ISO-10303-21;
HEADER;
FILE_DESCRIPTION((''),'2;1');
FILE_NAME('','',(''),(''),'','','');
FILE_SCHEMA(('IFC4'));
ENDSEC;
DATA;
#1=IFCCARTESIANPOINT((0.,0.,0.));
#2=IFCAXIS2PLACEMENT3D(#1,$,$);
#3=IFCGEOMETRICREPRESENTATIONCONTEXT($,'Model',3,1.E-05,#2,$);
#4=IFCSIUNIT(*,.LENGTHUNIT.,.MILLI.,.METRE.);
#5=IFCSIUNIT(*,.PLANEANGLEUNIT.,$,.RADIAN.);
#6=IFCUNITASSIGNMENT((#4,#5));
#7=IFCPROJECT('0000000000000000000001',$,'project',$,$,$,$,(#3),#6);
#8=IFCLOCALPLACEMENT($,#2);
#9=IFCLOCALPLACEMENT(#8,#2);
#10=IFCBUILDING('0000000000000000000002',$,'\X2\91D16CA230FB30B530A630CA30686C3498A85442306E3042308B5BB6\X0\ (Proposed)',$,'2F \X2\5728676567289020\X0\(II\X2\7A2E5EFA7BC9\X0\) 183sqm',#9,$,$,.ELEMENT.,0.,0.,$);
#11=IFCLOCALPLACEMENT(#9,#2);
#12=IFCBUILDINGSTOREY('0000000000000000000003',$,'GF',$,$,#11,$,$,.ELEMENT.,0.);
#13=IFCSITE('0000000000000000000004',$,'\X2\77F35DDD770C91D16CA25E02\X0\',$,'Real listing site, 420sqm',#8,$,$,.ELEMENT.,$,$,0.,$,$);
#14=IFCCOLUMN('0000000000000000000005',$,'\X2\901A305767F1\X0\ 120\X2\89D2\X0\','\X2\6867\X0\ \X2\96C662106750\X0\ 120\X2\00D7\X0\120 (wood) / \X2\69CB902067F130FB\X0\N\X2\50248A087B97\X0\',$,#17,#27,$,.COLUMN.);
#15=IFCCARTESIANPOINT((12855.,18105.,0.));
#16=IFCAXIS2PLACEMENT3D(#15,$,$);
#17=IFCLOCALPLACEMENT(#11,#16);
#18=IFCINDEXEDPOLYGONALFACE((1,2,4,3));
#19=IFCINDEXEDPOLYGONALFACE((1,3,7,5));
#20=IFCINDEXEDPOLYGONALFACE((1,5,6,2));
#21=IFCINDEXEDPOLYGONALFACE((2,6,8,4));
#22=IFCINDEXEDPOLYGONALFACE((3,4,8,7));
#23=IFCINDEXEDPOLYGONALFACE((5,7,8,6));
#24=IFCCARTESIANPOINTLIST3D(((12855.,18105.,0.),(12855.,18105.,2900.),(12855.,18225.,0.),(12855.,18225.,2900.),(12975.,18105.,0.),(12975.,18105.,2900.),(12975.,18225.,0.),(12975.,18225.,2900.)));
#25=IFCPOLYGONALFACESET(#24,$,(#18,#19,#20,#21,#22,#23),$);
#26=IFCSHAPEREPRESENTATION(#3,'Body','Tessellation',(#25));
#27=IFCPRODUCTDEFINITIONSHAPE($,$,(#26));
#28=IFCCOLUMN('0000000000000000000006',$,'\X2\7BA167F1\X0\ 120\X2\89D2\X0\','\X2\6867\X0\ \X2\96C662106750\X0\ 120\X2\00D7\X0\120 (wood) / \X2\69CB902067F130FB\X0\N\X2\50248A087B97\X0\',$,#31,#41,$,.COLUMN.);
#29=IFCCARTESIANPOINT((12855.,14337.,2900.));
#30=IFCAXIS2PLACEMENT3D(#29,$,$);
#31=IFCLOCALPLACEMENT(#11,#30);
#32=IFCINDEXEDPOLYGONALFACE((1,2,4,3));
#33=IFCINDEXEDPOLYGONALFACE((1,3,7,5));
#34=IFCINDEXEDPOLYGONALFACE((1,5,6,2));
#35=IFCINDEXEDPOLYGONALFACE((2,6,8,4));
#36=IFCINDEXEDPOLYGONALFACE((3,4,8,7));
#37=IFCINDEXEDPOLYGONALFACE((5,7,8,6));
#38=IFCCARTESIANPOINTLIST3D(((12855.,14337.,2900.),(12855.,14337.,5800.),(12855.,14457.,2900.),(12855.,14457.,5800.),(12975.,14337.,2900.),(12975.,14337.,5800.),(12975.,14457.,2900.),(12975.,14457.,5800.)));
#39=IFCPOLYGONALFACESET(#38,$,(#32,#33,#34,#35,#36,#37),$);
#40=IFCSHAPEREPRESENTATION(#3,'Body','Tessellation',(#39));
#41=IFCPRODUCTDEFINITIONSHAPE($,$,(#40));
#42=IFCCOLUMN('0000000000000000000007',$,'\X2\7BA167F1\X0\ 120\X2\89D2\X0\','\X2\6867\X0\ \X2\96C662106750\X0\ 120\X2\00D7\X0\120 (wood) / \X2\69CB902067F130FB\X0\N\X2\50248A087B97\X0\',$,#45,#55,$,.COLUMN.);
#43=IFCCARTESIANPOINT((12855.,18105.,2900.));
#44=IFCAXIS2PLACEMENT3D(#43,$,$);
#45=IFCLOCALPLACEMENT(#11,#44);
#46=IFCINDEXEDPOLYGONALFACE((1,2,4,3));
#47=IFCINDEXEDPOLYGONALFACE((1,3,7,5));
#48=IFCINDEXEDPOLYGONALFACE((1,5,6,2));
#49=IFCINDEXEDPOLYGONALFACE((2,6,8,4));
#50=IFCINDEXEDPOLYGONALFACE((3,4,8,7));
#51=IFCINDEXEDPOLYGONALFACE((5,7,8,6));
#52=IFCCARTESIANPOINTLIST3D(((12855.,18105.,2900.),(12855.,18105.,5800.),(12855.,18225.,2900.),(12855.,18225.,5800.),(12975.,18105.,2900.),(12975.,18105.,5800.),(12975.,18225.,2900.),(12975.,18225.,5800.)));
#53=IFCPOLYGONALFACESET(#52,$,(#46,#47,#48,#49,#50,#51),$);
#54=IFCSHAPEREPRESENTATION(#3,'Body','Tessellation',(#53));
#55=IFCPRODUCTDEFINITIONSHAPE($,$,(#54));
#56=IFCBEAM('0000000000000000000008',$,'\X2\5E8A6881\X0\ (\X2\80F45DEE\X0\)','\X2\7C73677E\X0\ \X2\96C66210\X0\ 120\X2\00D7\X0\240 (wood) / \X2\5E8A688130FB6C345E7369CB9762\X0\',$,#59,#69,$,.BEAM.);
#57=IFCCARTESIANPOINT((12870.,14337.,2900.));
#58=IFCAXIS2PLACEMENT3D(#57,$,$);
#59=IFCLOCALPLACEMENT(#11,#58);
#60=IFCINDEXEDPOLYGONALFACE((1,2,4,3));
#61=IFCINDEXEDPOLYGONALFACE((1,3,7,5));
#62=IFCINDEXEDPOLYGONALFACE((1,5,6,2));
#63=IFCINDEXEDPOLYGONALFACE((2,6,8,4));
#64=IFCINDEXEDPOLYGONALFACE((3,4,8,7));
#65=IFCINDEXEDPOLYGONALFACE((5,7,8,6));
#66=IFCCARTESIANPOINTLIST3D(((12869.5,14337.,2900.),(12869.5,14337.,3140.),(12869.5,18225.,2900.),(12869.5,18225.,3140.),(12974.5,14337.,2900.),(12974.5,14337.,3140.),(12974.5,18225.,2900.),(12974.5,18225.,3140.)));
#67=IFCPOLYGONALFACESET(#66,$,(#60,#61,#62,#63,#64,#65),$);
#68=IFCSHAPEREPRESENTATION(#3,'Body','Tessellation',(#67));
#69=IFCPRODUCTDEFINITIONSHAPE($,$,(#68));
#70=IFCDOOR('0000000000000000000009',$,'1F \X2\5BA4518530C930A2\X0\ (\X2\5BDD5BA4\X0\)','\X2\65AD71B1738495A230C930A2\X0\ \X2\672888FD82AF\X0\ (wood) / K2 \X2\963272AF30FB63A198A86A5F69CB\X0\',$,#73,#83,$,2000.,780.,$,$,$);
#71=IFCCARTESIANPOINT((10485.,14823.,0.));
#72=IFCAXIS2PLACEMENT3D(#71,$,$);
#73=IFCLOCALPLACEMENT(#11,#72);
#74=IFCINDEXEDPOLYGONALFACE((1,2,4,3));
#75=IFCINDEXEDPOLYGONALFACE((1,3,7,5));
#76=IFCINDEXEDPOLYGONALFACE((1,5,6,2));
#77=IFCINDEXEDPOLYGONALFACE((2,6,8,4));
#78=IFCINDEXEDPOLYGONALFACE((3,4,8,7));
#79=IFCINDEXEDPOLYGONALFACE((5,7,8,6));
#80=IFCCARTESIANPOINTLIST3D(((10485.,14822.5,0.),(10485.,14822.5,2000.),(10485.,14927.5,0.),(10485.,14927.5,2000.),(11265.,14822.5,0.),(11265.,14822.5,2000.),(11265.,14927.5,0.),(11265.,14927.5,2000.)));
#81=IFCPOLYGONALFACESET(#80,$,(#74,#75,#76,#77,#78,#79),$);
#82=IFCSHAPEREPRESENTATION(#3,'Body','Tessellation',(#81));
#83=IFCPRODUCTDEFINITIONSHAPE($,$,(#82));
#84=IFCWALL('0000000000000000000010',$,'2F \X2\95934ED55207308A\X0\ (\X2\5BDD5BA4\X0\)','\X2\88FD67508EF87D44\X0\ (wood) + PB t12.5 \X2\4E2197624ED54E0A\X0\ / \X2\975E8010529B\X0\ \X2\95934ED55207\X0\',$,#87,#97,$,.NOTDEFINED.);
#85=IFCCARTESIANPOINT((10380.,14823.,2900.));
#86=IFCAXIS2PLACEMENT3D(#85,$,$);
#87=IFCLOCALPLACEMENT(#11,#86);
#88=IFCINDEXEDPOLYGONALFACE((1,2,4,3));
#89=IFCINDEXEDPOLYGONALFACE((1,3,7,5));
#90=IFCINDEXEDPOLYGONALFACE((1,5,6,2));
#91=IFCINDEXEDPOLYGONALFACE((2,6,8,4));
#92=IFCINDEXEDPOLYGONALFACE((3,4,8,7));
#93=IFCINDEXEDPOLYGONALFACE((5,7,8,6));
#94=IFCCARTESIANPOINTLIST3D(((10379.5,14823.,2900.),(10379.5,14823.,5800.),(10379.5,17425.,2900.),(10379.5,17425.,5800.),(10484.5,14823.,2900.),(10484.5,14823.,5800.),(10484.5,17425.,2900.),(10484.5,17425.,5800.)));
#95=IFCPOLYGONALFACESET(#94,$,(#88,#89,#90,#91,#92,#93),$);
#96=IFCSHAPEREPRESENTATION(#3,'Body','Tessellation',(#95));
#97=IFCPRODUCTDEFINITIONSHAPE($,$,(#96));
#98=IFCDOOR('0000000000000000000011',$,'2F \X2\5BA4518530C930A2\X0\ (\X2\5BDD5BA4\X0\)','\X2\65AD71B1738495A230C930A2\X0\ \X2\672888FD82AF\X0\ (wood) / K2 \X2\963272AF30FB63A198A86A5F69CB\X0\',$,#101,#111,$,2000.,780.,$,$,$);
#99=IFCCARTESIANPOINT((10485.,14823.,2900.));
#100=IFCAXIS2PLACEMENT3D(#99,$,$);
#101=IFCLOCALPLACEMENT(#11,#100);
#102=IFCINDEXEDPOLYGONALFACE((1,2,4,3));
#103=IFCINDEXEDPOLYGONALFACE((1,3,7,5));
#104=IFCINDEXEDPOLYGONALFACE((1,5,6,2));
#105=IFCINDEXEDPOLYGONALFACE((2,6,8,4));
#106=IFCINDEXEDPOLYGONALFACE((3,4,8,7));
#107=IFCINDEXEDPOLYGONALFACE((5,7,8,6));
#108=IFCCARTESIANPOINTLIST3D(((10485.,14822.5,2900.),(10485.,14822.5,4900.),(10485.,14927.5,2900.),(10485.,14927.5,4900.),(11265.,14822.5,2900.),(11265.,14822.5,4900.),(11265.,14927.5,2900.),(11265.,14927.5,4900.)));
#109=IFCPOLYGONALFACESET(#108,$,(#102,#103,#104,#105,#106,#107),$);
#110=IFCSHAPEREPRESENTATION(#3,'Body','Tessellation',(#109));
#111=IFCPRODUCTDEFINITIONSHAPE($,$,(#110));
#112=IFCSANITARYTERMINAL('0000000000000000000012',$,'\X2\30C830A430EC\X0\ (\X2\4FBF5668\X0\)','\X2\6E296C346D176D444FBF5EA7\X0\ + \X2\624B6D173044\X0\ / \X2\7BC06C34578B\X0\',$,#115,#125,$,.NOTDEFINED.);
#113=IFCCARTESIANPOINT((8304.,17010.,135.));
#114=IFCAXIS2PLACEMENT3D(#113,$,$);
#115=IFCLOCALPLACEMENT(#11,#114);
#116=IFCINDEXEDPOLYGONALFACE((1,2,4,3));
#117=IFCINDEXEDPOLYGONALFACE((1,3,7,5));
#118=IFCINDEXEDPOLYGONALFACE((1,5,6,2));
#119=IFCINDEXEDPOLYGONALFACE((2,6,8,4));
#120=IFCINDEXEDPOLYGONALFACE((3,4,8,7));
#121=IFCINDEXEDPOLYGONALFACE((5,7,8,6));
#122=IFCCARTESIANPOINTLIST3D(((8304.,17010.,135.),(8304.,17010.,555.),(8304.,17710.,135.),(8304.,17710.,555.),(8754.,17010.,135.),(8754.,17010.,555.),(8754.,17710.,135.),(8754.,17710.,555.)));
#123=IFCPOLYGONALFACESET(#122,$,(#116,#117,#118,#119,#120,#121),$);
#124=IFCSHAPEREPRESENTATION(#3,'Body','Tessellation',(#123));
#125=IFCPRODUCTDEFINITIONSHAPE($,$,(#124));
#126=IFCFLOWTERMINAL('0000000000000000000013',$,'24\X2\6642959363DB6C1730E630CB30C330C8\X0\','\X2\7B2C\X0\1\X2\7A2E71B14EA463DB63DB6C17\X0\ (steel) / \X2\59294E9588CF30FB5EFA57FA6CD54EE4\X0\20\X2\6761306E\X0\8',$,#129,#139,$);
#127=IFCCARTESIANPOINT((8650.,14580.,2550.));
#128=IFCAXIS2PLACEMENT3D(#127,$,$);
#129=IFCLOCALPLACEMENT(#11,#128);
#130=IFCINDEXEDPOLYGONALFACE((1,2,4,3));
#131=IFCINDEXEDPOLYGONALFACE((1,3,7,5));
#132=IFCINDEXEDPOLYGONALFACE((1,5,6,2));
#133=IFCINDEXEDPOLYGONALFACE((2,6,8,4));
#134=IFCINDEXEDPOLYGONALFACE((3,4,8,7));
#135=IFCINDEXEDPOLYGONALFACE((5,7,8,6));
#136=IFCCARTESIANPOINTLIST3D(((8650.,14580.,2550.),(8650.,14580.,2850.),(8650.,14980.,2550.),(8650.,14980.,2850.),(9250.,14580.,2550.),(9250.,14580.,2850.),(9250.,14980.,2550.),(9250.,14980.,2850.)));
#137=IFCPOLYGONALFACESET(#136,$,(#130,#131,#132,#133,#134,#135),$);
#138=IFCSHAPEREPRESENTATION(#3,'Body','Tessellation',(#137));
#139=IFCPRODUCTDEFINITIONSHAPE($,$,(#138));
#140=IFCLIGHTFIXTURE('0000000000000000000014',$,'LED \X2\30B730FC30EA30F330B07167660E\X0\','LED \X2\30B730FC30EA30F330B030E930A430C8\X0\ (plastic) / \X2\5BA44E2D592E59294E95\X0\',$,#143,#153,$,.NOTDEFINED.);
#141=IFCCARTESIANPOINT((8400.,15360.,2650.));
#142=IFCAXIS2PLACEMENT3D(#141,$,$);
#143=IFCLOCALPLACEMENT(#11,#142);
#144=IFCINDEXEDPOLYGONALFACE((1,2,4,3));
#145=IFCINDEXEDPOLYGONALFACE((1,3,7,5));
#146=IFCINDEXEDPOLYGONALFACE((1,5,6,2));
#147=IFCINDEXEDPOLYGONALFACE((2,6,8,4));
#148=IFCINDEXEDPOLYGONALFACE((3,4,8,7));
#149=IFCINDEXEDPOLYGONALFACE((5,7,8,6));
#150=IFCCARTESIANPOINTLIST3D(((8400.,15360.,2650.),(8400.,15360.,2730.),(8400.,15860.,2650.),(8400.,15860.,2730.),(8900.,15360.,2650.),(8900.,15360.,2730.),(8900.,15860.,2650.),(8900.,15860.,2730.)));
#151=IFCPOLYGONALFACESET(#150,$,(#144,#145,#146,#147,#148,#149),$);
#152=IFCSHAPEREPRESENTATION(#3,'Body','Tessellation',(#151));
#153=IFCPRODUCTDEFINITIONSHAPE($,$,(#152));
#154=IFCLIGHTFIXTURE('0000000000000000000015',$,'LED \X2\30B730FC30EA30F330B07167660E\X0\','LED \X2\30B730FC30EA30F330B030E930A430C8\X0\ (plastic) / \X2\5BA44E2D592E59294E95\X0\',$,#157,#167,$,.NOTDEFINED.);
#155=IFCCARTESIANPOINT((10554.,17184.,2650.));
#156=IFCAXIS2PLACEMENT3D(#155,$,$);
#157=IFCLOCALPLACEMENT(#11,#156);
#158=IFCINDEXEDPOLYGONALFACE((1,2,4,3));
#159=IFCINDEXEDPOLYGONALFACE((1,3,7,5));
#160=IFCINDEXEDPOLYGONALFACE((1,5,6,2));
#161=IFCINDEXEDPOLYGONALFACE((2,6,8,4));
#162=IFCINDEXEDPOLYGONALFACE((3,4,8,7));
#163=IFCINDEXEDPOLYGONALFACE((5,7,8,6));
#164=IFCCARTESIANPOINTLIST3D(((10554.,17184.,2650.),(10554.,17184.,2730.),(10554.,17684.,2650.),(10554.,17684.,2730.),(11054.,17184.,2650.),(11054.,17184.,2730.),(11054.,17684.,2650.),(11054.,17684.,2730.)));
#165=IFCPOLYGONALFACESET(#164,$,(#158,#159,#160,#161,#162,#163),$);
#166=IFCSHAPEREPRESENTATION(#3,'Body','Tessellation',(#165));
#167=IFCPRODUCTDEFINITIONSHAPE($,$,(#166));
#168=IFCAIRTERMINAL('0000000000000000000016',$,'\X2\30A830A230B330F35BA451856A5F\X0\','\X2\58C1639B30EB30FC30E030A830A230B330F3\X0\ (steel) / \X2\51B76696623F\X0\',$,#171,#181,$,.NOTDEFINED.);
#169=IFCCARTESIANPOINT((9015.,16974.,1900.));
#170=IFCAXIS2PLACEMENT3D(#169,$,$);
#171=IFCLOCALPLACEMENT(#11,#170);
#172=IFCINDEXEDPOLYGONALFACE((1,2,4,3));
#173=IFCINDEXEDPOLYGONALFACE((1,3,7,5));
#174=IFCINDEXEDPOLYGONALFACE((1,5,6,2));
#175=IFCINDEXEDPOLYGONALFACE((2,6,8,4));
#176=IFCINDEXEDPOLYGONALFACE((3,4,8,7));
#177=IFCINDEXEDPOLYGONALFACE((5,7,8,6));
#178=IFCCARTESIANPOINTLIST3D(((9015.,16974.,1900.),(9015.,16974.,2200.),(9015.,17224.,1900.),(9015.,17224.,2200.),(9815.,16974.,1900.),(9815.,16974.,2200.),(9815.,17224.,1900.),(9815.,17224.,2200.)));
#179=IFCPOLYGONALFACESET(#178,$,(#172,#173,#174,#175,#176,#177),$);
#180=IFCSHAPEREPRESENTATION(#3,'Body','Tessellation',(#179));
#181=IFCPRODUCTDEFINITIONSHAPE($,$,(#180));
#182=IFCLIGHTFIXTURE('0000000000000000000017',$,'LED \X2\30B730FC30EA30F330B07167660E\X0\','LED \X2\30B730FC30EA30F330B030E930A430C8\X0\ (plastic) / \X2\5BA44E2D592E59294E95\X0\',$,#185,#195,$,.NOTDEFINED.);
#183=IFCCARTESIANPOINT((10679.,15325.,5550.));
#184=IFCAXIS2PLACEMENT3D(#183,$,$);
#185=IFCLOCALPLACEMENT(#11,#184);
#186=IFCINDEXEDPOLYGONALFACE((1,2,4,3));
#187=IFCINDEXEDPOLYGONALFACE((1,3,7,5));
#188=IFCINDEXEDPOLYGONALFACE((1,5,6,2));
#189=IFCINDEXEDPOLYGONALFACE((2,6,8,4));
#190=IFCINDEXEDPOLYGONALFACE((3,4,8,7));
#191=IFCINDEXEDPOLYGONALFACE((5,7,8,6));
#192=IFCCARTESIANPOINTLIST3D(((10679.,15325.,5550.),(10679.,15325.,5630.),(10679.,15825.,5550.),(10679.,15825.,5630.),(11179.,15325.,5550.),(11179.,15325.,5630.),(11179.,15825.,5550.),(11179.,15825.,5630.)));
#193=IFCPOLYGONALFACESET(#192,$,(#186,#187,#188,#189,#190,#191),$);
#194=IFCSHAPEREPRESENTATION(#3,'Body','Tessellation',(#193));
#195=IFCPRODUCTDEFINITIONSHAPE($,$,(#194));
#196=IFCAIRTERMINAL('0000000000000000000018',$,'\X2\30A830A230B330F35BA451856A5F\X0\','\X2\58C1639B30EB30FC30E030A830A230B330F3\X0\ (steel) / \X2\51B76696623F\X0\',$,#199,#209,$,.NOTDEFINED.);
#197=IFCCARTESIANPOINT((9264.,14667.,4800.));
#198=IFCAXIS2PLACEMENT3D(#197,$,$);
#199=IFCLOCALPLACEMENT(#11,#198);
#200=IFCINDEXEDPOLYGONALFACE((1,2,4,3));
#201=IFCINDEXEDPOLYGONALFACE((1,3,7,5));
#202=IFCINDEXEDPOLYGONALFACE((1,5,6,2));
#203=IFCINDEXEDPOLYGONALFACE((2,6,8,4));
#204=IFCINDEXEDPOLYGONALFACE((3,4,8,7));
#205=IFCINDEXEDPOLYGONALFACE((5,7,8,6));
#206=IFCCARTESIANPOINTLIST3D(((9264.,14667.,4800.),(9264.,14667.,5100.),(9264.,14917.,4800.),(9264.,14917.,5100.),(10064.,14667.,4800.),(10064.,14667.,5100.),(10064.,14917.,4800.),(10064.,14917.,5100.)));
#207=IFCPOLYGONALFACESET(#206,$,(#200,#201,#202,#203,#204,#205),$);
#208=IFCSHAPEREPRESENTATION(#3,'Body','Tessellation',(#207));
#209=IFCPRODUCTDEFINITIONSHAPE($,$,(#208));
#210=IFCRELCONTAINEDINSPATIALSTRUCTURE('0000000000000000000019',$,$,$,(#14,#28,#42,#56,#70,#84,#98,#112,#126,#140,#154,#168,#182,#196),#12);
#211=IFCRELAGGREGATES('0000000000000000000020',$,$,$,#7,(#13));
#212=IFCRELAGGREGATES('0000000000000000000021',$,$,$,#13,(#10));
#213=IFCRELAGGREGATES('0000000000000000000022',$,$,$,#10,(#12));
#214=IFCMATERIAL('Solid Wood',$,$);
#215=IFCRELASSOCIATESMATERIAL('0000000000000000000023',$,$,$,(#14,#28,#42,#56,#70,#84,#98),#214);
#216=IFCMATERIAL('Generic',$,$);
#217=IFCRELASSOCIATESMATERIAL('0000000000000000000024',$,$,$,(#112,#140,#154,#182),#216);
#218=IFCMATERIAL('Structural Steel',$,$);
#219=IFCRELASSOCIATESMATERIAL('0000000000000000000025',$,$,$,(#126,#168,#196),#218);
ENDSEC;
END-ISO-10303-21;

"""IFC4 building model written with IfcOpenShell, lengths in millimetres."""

from ifc_helpers import new_model, si_unit, frame, frame_2d, origin, place, context, project, spatial, rectangle, extrude, material, element, save


model = new_model("IFC4")

# Units and contexts
model_context = context("Model", 3, precision=1e-05, world=origin())
ifc_project = project(units=[si_unit("LENGTHUNIT", "METRE", prefix="MILLI"), si_unit("PLANEANGLEUNIT", "RADIAN")], contexts=[model_context])

# Site, building, storey
site_placement = place(None, origin())
site = spatial("IfcSite", under=ifc_project, at=site_placement, Name="石川県金沢市", ObjectType="Real listing site, 420sqm", CompositionType="ELEMENT", RefElevation=0.0)
building_placement = place(site_placement, origin())
building = spatial("IfcBuilding", under=site, at=building_placement, Name="金沢・サウナと水風呂のある家 (Proposed)", ObjectType="2F 在来木造(II種建築) 183sqm", CompositionType="ELEMENT", ElevationOfRefHeight=0.0, ElevationOfTerrain=0.0)
storey_placement = place(building_placement, origin())
storey = spatial("IfcBuildingStorey", under=building, at=storey_placement, Name="GF", CompositionType="ELEMENT", Elevation=0.0)

# Columns
ifc_material_1 = material(Name="Solid Wood")
column_1_placement = place(storey_placement, frame((12855.0, 18105.0, 0.0)))
element("IfcColumn", 1, at=column_1_placement, inside=storey, material=ifc_material_1, Name="通し柱 120角", Description="桧 集成材 120×120 (wood) / 構造柱・N値計算", PredefinedType="COLUMN", context=model_context, shape_type="SweptSolid", body=[
    extrude(rectangle(XDim=120.0, YDim=120.0, at=frame_2d((60.0, 60.0))), frame((12855.0, 18105.0, 0.0)), (0.0, 0.0, 1.0), 2900.0),
])
column_2_placement = place(storey_placement, frame((12855.0, 14337.0, 2900.0)))
element("IfcColumn", 2, at=column_2_placement, inside=storey, material=ifc_material_1, Name="管柱 120角", Description="桧 集成材 120×120 (wood) / 構造柱・N値計算", PredefinedType="COLUMN", context=model_context, shape_type="SweptSolid", body=[
    extrude(rectangle(XDim=120.0, YDim=120.0, at=frame_2d((60.0, 60.0))), frame((12855.0, 14337.0, 2900.0)), (0.0, 0.0, 1.0), 2900.0),
])
column_3_placement = place(storey_placement, frame((12855.0, 18105.0, 2900.0)))
element("IfcColumn", 3, at=column_3_placement, inside=storey, material=ifc_material_1, Name="管柱 120角", Description="桧 集成材 120×120 (wood) / 構造柱・N値計算", PredefinedType="COLUMN", context=model_context, shape_type="SweptSolid", body=[
    extrude(rectangle(XDim=120.0, YDim=120.0, at=frame_2d((60.0, 60.0))), frame((12855.0, 18105.0, 2900.0)), (0.0, 0.0, 1.0), 2900.0),
])

# Beam
beam_1_placement = place(storey_placement, frame((12870.0, 14337.0, 2900.0)))
element("IfcBeam", 4, at=beam_1_placement, inside=storey, material=ifc_material_1, Name="床梁 (胴差)", Description="米松 集成 120×240 (wood) / 床梁・水平構面", PredefinedType="BEAM", context=model_context, shape_type="SweptSolid", body=[
    extrude(rectangle(XDim=105.0, YDim=3888.0, at=frame_2d((52.0, 1944.0))), frame((12870.0, 14337.0, 2900.0)), (0.0, 0.0, 1.0), 240.0),
])

# Door
door_1_placement = place(storey_placement, frame((10485.0, 14823.0, 0.0)))
element("IfcDoor", 5, at=door_1_placement, inside=storey, material=ifc_material_1, Name="1F 室内ドア (寝室)", Description="断熱玄関ドア 木製芯 (wood) / K2 防犯・採風機構", OverallHeight=2000.0, OverallWidth=780.0, context=model_context, shape_type="SweptSolid", body=[
    extrude(rectangle(XDim=780.0, YDim=105.0, at=frame_2d((390.0, 52.0))), frame((10485.0, 14823.0, 0.0)), (0.0, 0.0, 1.0), 2000.0),
])

# Wall
wall_1_placement = place(storey_placement, frame((10380.0, 14823.0, 2900.0)))
element("IfcWall", 6, at=wall_1_placement, inside=storey, material=ifc_material_1, Name="2F 間仕切り (寝室)", Description="製材軸組 (wood) + PB t12.5 両面仕上 / 非耐力 間仕切", PredefinedType="NOTDEFINED", context=model_context, shape_type="SweptSolid", body=[
    extrude(rectangle(XDim=105.0, YDim=2602.0, at=frame_2d((52.0, 1301.0))), frame((10380.0, 14823.0, 2900.0)), (0.0, 0.0, 1.0), 2900.0),
])

# Door
door_2_placement = place(storey_placement, frame((10485.0, 14823.0, 2900.0)))
element("IfcDoor", 7, at=door_2_placement, inside=storey, material=ifc_material_1, Name="2F 室内ドア (寝室)", Description="断熱玄関ドア 木製芯 (wood) / K2 防犯・採風機構", OverallHeight=2000.0, OverallWidth=780.0, context=model_context, shape_type="SweptSolid", body=[
    extrude(rectangle(XDim=780.0, YDim=105.0, at=frame_2d((390.0, 52.0))), frame((10485.0, 14823.0, 2900.0)), (0.0, 0.0, 1.0), 2000.0),
])

# Sanitary terminal
ifc_material_2 = material(Name="Generic")
sanitary_terminal_placement = place(storey_placement, frame((8304.0, 17010.0, 135.0)))
element("IfcSanitaryTerminal", 8, at=sanitary_terminal_placement, inside=storey, material=ifc_material_2, Name="トイレ (便器)", Description="温水洗浄便座 + 手洗い / 節水型", PredefinedType="NOTDEFINED", context=model_context, shape_type="SweptSolid", body=[
    extrude(rectangle(XDim=450.0, YDim=700.0, at=frame_2d((225.0, 350.0))), frame((8304.0, 17010.0, 135.0)), (0.0, 0.0, 1.0), 420.0),
])

# Flow terminal
ifc_material_3 = material(Name="Structural Steel")
flow_terminal_placement = place(storey_placement, frame((8650.0, 14580.0, 2550.0)))
element("IfcFlowTerminal", 9, at=flow_terminal_placement, inside=storey, material=ifc_material_3, Name="24時間換気ユニット", Description="第1種熱交換換気 (steel) / 天井裏・建基法令20条の8", context=model_context, shape_type="SweptSolid", body=[
    extrude(rectangle(XDim=600.0, YDim=400.0, at=frame_2d((300.0, 200.0))), frame((8650.0, 14580.0, 2550.0)), (0.0, 0.0, 1.0), 300.0),
])

# Light fixtures
light_fixture_1_placement = place(storey_placement, frame((8400.0, 15360.0, 2650.0)))
element("IfcLightFixture", 10, at=light_fixture_1_placement, inside=storey, material=ifc_material_2, Name="LED シーリング照明", Description="LED シーリングライト (plastic) / 室中央天井", PredefinedType="NOTDEFINED", context=model_context, shape_type="SweptSolid", body=[
    extrude(rectangle(XDim=500.0, YDim=500.0, at=frame_2d((250.0, 250.0))), frame((8400.0, 15360.0, 2650.0)), (0.0, 0.0, 1.0), 80.0),
])
light_fixture_2_placement = place(storey_placement, frame((10554.0, 17184.0, 2650.0)))
element("IfcLightFixture", 11, at=light_fixture_2_placement, inside=storey, material=ifc_material_2, Name="LED シーリング照明", Description="LED シーリングライト (plastic) / 室中央天井", PredefinedType="NOTDEFINED", context=model_context, shape_type="SweptSolid", body=[
    extrude(rectangle(XDim=500.0, YDim=500.0, at=frame_2d((250.0, 250.0))), frame((10554.0, 17184.0, 2650.0)), (0.0, 0.0, 1.0), 80.0),
])

# Air terminal
air_terminal_1_placement = place(storey_placement, frame((9015.0, 16974.0, 1900.0)))
element("IfcAirTerminal", 12, at=air_terminal_1_placement, inside=storey, material=ifc_material_3, Name="エアコン室内機", Description="壁掛ルームエアコン (steel) / 冷暖房", PredefinedType="NOTDEFINED", context=model_context, shape_type="SweptSolid", body=[
    extrude(rectangle(XDim=800.0, YDim=250.0, at=frame_2d((400.0, 125.0))), frame((9015.0, 16974.0, 1900.0)), (0.0, 0.0, 1.0), 300.0),
])

# Light fixture
light_fixture_3_placement = place(storey_placement, frame((10679.0, 15325.0, 5550.0)))
element("IfcLightFixture", 13, at=light_fixture_3_placement, inside=storey, material=ifc_material_2, Name="LED シーリング照明", Description="LED シーリングライト (plastic) / 室中央天井", PredefinedType="NOTDEFINED", context=model_context, shape_type="SweptSolid", body=[
    extrude(rectangle(XDim=500.0, YDim=500.0, at=frame_2d((250.0, 250.0))), frame((10679.0, 15325.0, 5550.0)), (0.0, 0.0, 1.0), 80.0),
])

# Air terminal
air_terminal_2_placement = place(storey_placement, frame((9264.0, 14667.0, 4800.0)))
element("IfcAirTerminal", 14, at=air_terminal_2_placement, inside=storey, material=ifc_material_3, Name="エアコン室内機", Description="壁掛ルームエアコン (steel) / 冷暖房", PredefinedType="NOTDEFINED", context=model_context, shape_type="SweptSolid", body=[
    extrude(rectangle(XDim=800.0, YDim=250.0, at=frame_2d((400.0, 125.0))), frame((9264.0, 14667.0, 4800.0)), (0.0, 0.0, 1.0), 300.0),
])

save(model, "model.ifc")
